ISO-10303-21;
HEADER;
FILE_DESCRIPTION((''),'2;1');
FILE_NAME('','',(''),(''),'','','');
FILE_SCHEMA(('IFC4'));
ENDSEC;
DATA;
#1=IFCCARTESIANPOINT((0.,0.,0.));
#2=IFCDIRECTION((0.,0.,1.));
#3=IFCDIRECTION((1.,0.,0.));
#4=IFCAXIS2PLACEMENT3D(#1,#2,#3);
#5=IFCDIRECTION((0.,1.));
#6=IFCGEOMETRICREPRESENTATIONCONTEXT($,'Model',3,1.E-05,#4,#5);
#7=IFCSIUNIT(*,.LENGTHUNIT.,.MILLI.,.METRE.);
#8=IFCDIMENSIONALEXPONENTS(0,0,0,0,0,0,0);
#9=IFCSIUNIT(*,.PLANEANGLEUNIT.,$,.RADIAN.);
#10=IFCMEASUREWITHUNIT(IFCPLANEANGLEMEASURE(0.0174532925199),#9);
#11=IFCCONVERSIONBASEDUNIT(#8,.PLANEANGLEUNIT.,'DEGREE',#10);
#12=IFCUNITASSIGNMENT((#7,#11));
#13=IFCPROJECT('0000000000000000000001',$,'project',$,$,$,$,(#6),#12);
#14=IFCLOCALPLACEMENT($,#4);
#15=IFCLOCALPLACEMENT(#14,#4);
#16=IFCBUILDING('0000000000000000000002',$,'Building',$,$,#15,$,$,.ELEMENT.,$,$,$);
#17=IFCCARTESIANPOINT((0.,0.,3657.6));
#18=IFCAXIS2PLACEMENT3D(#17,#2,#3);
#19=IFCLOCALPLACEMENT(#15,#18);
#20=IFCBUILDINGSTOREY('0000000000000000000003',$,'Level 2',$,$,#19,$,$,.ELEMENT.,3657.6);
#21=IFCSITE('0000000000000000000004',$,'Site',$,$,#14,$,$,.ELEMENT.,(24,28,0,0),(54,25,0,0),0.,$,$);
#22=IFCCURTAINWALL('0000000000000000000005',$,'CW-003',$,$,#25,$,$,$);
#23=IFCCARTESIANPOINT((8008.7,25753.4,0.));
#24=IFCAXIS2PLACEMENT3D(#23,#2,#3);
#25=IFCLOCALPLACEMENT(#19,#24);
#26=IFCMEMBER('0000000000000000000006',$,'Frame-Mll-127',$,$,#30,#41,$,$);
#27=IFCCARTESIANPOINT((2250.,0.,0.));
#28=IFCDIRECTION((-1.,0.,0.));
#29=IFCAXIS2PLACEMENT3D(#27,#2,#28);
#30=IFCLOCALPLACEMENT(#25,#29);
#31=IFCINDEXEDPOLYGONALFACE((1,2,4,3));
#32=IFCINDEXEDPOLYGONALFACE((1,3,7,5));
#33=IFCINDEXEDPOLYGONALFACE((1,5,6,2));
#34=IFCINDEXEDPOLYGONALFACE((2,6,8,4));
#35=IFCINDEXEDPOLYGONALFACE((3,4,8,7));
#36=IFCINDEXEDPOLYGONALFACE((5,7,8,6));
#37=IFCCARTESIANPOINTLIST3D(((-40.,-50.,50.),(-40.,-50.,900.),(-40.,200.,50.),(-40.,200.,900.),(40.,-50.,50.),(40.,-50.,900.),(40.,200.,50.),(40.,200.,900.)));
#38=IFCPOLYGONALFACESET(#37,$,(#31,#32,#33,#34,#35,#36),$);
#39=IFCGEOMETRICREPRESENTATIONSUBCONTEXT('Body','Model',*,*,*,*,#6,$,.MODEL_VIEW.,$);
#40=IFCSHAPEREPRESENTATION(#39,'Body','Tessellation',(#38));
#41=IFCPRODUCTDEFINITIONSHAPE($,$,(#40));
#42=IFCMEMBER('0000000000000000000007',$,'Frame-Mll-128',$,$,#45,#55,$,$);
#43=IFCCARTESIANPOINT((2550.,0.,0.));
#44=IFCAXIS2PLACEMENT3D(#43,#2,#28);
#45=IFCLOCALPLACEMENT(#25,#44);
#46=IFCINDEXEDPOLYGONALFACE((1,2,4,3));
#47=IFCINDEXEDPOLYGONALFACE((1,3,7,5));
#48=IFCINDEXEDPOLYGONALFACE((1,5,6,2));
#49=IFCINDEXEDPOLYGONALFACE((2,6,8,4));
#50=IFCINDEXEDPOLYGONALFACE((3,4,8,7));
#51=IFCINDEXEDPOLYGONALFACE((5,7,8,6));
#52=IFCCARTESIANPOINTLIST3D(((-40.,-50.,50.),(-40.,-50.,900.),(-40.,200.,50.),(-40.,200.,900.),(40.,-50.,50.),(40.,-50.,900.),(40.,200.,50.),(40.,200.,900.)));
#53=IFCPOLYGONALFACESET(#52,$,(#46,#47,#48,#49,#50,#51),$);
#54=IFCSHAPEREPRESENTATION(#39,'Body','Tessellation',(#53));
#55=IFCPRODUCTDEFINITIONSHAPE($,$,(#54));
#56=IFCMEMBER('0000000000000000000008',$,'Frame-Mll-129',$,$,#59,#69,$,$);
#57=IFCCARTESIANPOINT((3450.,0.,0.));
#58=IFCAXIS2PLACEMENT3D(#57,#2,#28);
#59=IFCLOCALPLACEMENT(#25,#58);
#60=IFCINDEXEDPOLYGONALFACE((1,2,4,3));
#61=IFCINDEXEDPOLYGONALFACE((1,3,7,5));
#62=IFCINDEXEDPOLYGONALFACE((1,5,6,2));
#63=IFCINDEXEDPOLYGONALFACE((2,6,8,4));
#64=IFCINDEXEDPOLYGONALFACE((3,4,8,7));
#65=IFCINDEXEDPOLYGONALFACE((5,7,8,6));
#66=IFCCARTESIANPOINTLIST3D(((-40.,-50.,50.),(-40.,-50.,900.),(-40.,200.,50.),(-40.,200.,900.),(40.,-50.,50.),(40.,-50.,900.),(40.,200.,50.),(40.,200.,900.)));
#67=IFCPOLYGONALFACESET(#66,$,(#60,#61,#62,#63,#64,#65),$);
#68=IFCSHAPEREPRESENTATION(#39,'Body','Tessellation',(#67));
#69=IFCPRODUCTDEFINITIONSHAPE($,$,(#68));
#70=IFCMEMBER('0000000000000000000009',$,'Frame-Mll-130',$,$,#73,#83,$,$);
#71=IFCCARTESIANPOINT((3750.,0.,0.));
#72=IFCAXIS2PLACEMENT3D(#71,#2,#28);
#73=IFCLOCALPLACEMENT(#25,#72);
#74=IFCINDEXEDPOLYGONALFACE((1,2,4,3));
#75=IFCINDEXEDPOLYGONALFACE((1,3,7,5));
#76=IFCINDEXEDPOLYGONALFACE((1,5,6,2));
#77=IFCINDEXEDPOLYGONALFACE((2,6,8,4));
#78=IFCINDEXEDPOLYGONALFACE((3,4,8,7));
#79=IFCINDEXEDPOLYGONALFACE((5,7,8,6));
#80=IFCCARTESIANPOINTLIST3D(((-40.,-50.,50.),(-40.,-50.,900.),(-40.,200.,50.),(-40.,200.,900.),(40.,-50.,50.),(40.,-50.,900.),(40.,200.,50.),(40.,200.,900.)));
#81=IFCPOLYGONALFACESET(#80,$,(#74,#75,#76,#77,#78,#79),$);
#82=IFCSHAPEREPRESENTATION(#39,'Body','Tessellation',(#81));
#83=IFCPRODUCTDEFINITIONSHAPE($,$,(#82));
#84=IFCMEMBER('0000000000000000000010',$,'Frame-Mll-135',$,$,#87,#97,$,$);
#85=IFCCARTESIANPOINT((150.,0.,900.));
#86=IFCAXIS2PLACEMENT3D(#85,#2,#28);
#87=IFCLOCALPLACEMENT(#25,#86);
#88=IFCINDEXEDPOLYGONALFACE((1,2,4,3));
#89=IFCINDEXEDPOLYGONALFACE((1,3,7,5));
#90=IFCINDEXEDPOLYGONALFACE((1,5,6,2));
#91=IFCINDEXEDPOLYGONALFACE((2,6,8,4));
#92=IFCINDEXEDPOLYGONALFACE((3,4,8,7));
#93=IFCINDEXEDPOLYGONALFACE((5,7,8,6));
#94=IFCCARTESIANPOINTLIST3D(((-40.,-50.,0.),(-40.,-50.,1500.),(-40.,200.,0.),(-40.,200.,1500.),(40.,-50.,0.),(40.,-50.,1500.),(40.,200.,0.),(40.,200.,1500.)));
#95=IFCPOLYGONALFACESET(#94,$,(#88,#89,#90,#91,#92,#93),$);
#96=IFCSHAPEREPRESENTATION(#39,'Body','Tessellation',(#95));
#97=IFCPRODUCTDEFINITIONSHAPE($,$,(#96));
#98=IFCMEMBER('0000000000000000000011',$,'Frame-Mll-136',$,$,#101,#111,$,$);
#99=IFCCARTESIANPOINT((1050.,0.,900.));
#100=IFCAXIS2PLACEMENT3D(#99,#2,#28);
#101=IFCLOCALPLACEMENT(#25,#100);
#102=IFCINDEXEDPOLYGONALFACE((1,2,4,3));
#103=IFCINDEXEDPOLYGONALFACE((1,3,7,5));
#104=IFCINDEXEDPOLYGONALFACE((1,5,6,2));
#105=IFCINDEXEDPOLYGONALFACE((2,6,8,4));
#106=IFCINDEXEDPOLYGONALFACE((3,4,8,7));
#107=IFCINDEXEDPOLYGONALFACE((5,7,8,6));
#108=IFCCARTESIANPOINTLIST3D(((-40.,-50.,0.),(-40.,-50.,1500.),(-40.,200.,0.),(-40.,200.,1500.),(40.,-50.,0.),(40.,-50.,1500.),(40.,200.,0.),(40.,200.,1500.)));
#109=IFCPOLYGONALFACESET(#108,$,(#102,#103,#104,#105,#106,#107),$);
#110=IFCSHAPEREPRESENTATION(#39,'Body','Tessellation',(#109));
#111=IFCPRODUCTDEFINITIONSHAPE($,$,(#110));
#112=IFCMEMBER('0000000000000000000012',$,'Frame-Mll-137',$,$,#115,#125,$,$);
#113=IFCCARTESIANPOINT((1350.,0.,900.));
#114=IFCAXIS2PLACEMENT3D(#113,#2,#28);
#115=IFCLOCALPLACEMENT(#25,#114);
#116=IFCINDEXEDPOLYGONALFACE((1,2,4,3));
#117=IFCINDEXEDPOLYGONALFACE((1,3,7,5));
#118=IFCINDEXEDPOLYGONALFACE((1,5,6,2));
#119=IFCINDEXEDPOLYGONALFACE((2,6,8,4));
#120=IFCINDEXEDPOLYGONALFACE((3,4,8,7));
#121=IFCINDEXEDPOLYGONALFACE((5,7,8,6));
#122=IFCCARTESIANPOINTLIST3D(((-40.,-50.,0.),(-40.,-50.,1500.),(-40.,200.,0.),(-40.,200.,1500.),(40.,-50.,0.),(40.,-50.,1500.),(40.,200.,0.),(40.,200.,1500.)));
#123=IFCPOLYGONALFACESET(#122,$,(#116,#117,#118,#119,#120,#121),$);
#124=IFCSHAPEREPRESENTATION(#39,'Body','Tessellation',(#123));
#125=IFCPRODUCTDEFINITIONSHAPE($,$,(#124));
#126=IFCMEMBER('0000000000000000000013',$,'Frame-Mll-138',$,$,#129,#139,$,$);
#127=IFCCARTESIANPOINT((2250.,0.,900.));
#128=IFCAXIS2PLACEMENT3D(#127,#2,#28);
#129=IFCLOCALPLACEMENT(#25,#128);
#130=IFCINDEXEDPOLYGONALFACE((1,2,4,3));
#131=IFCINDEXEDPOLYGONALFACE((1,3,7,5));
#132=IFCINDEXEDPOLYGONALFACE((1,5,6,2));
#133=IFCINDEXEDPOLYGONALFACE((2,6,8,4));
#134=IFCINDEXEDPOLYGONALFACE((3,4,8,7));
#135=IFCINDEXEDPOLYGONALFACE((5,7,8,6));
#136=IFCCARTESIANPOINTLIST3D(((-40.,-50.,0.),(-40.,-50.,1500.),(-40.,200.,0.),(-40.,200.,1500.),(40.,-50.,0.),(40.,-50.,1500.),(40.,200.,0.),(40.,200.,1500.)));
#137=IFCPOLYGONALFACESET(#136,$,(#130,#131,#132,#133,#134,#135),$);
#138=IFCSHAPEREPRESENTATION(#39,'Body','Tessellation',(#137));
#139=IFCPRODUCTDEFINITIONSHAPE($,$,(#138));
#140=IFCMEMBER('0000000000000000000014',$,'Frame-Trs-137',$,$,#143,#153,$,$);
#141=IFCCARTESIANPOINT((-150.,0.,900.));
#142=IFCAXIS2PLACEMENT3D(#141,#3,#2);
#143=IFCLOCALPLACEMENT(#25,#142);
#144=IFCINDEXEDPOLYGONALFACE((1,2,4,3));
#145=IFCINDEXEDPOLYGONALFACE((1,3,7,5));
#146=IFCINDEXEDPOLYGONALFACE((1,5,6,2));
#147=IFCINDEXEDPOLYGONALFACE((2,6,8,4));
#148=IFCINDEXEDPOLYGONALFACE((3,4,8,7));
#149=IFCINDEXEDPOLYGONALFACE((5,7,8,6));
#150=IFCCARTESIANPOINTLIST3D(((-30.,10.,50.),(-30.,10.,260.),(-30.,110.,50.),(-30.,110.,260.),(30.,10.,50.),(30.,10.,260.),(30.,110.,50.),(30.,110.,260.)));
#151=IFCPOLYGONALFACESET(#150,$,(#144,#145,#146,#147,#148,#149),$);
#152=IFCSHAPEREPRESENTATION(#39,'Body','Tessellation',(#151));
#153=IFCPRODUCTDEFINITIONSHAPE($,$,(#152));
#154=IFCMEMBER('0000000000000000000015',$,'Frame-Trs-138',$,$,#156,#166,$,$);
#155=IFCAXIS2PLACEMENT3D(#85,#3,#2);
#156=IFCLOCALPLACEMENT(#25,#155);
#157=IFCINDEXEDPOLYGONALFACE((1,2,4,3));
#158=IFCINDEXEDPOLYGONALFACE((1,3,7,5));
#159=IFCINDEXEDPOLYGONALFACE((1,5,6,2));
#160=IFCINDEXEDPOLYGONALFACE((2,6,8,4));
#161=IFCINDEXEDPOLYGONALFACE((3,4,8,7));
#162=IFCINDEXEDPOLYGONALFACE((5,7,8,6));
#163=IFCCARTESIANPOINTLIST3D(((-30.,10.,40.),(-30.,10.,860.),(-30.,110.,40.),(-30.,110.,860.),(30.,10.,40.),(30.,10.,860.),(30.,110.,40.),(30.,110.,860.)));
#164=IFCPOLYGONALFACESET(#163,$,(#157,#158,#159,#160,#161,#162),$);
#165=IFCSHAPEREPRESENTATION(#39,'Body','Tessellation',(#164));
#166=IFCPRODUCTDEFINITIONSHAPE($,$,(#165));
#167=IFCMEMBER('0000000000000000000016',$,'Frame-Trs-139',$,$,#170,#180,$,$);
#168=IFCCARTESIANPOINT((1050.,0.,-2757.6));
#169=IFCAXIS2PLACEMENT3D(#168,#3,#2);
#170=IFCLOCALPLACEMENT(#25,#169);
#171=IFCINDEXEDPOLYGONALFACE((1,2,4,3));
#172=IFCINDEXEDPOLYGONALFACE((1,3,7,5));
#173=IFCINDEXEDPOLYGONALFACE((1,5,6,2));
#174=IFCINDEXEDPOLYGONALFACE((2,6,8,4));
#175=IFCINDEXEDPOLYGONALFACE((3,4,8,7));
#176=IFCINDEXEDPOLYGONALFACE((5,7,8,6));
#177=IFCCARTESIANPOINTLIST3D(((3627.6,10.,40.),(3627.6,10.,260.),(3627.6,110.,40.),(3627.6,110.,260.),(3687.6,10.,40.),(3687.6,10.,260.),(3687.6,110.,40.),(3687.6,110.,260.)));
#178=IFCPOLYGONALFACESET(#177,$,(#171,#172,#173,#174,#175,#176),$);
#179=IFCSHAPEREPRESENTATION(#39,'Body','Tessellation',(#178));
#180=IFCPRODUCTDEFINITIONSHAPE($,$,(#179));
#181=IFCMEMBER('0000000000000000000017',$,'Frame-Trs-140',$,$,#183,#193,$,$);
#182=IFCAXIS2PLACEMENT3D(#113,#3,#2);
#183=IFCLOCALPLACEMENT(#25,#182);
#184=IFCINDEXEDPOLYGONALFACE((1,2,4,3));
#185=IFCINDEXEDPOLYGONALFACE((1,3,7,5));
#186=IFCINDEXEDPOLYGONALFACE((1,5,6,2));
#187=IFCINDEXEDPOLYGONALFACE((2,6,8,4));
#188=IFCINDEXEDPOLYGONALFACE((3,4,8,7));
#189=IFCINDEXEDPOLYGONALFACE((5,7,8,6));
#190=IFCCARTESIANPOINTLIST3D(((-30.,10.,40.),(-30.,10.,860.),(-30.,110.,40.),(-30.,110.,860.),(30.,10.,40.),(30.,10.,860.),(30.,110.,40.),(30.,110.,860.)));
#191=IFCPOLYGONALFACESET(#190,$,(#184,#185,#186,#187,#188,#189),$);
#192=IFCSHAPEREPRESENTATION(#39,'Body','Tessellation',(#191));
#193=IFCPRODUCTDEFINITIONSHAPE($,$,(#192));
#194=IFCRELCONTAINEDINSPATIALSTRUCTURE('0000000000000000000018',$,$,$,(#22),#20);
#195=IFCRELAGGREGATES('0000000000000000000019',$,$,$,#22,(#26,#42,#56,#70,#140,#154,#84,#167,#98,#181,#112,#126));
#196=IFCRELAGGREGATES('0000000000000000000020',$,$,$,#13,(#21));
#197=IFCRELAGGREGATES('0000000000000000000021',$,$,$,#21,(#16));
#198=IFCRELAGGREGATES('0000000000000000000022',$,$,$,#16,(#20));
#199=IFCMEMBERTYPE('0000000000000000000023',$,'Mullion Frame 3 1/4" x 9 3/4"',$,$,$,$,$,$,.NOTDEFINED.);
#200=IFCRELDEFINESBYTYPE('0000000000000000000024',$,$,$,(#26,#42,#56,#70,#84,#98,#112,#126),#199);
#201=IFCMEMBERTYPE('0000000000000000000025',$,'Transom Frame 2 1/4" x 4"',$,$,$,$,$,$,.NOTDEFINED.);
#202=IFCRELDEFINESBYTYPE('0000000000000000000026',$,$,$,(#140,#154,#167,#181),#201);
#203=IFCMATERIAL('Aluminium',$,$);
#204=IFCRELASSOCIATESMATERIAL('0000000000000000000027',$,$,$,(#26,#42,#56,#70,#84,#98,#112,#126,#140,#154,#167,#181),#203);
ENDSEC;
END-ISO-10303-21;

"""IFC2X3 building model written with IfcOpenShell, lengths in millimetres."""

from ifc_helpers import new_model, entity, si_unit, converted_unit, direction, frame, origin_with_axes, place, context, subcontext, project, spatial, polyline, outline, extrude, material, type_object, element, aggregate, save


model = new_model("IFC2X3")

# Units and contexts
model_context = context("Model", 3, precision=1e-05, world=origin_with_axes(), true_north=direction((0.0, 1.0)))
body_context = subcontext(model_context, "Body", "Model", "MODEL_VIEW")
ifc_project = project(units=[si_unit("LENGTHUNIT", "METRE", prefix="MILLI"), converted_unit("PLANEANGLEUNIT", "DEGREE", entity("IfcPlaneAngleMeasure", 0.0174532925199), si_unit("PLANEANGLEUNIT", "RADIAN"), dimensions=[0, 0, 0, 0, 0, 0, 0])], contexts=[model_context])

# Site, building, storey
site_placement = place(None, origin_with_axes())
site = spatial("IfcSite", under=ifc_project, at=site_placement, Name="Site", CompositionType="ELEMENT", RefLatitude=(24, 28, 0, 0), RefLongitude=(54, 25, 0, 0), RefElevation=0.0)
building_placement = place(site_placement, origin_with_axes())
building = spatial("IfcBuilding", under=site, at=building_placement, Name="Building", CompositionType="ELEMENT")
storey_placement = place(building_placement, frame((0.0, 0.0, 3657.6), z_axis=(0.0, 0.0, 1.0), x_axis=(1.0, 0.0, 0.0)))
storey = spatial("IfcBuildingStorey", under=building, at=storey_placement, Name="Level 2", CompositionType="ELEMENT", Elevation=3657.6)

# Curtain wall, members
curtain_wall_placement = place(storey_placement, frame((8008.7, 25753.4, 0.0), z_axis=(0.0, 0.0, 1.0), x_axis=(1.0, 0.0, 0.0)))
curtain_wall = element("IfcCurtainWall", 1, at=curtain_wall_placement, inside=storey, Name="CW-003")
ifc_material_1 = material(Name="Aluminium")
member_type_1 = type_object("IfcMemberType", Name="Mullion Frame 3 1/4\" x 9 3/4\"", PredefinedType="NOTDEFINED")
member_1_placement = place(curtain_wall_placement, frame((2250.0, 0.0, 0.0), z_axis=(0.0, 0.0, 1.0), x_axis=(-1.0, 0.0, 0.0)))
member_1 = element("IfcMember", 2, at=member_1_placement, type_object=member_type_1, material=ifc_material_1, Name="Frame-Mll-127", context=body_context, shape_type="SweptSolid", body=[
    extrude(outline(polyline([(-40.0, -200.0), (40.0, -200.0), (40.0, 50.0), (-40.0, 50.0), (-40.0, -200.0)])), frame((0.0, 0.0, 50.0), z_axis=(0.0, 0.0, 1.0), x_axis=(-1.0, 0.0, 0.0)), (0.0, 0.0, 1.0), 850.0),
])
member_2_placement = place(curtain_wall_placement, frame((2550.0, 0.0, 0.0), z_axis=(0.0, 0.0, 1.0), x_axis=(-1.0, 0.0, 0.0)))
member_2 = element("IfcMember", 3, at=member_2_placement, type_object=member_type_1, material=ifc_material_1, Name="Frame-Mll-128", context=body_context, shape_type="SweptSolid", body=[
    extrude(outline(polyline([(-40.0, -200.0), (40.0, -200.0), (40.0, 50.0), (-40.0, 50.0), (-40.0, -200.0)])), frame((0.0, 0.0, 50.0), z_axis=(0.0, 0.0, 1.0), x_axis=(-1.0, 0.0, 0.0)), (0.0, 0.0, 1.0), 850.0),
])
member_3_placement = place(curtain_wall_placement, frame((3450.0, 0.0, 0.0), z_axis=(0.0, 0.0, 1.0), x_axis=(-1.0, 0.0, 0.0)))
member_3 = element("IfcMember", 4, at=member_3_placement, type_object=member_type_1, material=ifc_material_1, Name="Frame-Mll-129", context=body_context, shape_type="SweptSolid", body=[
    extrude(outline(polyline([(-40.0, -200.0), (40.0, -200.0), (40.0, 50.0), (-40.0, 50.0), (-40.0, -200.0)])), frame((0.0, 0.0, 50.0), z_axis=(0.0, 0.0, 1.0), x_axis=(-1.0, 0.0, 0.0)), (0.0, 0.0, 1.0), 850.0),
])
member_4_placement = place(curtain_wall_placement, frame((3750.0, 0.0, 0.0), z_axis=(0.0, 0.0, 1.0), x_axis=(-1.0, 0.0, 0.0)))
member_4 = element("IfcMember", 5, at=member_4_placement, type_object=member_type_1, material=ifc_material_1, Name="Frame-Mll-130", context=body_context, shape_type="SweptSolid", body=[
    extrude(outline(polyline([(-40.0, -200.0), (40.0, -200.0), (40.0, 50.0), (-40.0, 50.0), (-40.0, -200.0)])), frame((0.0, 0.0, 50.0), z_axis=(0.0, 0.0, 1.0), x_axis=(-1.0, 0.0, 0.0)), (0.0, 0.0, 1.0), 850.0),
])
member_5_placement = place(curtain_wall_placement, frame((150.0, 0.0, 900.0), z_axis=(0.0, 0.0, 1.0), x_axis=(-1.0, 0.0, 0.0)))
member_5 = element("IfcMember", 6, at=member_5_placement, type_object=member_type_1, material=ifc_material_1, Name="Frame-Mll-135", context=body_context, shape_type="SweptSolid", body=[
    extrude(outline(polyline([(-40.0, -200.0), (40.0, -200.0), (40.0, 50.0), (-40.0, 50.0), (-40.0, -200.0)])), frame((0.0, 0.0, 0.0), z_axis=(0.0, 0.0, 1.0), x_axis=(-1.0, 0.0, 0.0)), (0.0, 0.0, 1.0), 1500.0),
])
member_6_placement = place(curtain_wall_placement, frame((1050.0, 0.0, 900.0), z_axis=(0.0, 0.0, 1.0), x_axis=(-1.0, 0.0, 0.0)))
member_6 = element("IfcMember", 7, at=member_6_placement, type_object=member_type_1, material=ifc_material_1, Name="Frame-Mll-136", context=body_context, shape_type="SweptSolid", body=[
    extrude(outline(polyline([(-40.0, -200.0), (40.0, -200.0), (40.0, 50.0), (-40.0, 50.0), (-40.0, -200.0)])), frame((0.0, 0.0, 0.0), z_axis=(0.0, 0.0, 1.0), x_axis=(-1.0, 0.0, 0.0)), (0.0, 0.0, 1.0), 1500.0),
])
member_7_placement = place(curtain_wall_placement, frame((1350.0, 0.0, 900.0), z_axis=(0.0, 0.0, 1.0), x_axis=(-1.0, 0.0, 0.0)))
member_7 = element("IfcMember", 8, at=member_7_placement, type_object=member_type_1, material=ifc_material_1, Name="Frame-Mll-137", context=body_context, shape_type="SweptSolid", body=[
    extrude(outline(polyline([(-40.0, -200.0), (40.0, -200.0), (40.0, 50.0), (-40.0, 50.0), (-40.0, -200.0)])), frame((0.0, 0.0, 0.0), z_axis=(0.0, 0.0, 1.0), x_axis=(-1.0, 0.0, 0.0)), (0.0, 0.0, 1.0), 1500.0),
])
member_8_placement = place(curtain_wall_placement, frame((2250.0, 0.0, 900.0), z_axis=(0.0, 0.0, 1.0), x_axis=(-1.0, 0.0, 0.0)))
member_8 = element("IfcMember", 9, at=member_8_placement, type_object=member_type_1, material=ifc_material_1, Name="Frame-Mll-138", context=body_context, shape_type="SweptSolid", body=[
    extrude(outline(polyline([(-40.0, -200.0), (40.0, -200.0), (40.0, 50.0), (-40.0, 50.0), (-40.0, -200.0)])), frame((0.0, 0.0, 0.0), z_axis=(0.0, 0.0, 1.0), x_axis=(-1.0, 0.0, 0.0)), (0.0, 0.0, 1.0), 1500.0),
])
member_type_2 = type_object("IfcMemberType", Name="Transom Frame 2 1/4\" x 4\"", PredefinedType="NOTDEFINED")
member_9_placement = place(curtain_wall_placement, frame((-150.0, 0.0, 900.0), z_axis=(1.0, 0.0, 0.0), x_axis=(0.0, 0.0, 1.0)))
member_9 = element("IfcMember", 10, at=member_9_placement, type_object=member_type_2, material=ifc_material_1, Name="Frame-Trs-137", context=body_context, shape_type="SweptSolid", body=[
    extrude(outline(polyline([(110.0, -30.0), (110.0, 30.0), (10.0, 30.0), (10.0, -30.0), (110.0, -30.0)])), frame((0.0, 0.0, 50.0), z_axis=(0.0, 0.0, 1.0), x_axis=(0.0, 1.0, 0.0)), (0.0, 0.0, 1.0), 210.0),
])
member_10_placement = place(curtain_wall_placement, frame((150.0, 0.0, 900.0), z_axis=(1.0, 0.0, 0.0), x_axis=(0.0, 0.0, 1.0)))
member_10 = element("IfcMember", 11, at=member_10_placement, type_object=member_type_2, material=ifc_material_1, Name="Frame-Trs-138", context=body_context, shape_type="SweptSolid", body=[
    extrude(outline(polyline([(110.0, -30.0), (110.0, 30.0), (10.0, 30.0), (10.0, -30.0), (110.0, -30.0)])), frame((0.0, 0.0, 40.0), z_axis=(0.0, 0.0, 1.0), x_axis=(0.0, 1.0, 0.0)), (0.0, 0.0, 1.0), 820.0),
])
member_11_placement = place(curtain_wall_placement, frame((1050.0, 0.0, -2757.6), z_axis=(1.0, 0.0, 0.0), x_axis=(0.0, 0.0, 1.0)))
member_11 = element("IfcMember", 12, at=member_11_placement, type_object=member_type_2, material=ifc_material_1, Name="Frame-Trs-139", context=body_context, shape_type="SweptSolid", body=[
    extrude(outline(polyline([(110.0, -3687.6), (110.0, -3627.6), (10.0, -3627.6), (10.0, -3687.6), (110.0, -3687.6)])), frame((0.0, 0.0, 40.0), z_axis=(0.0, 0.0, 1.0), x_axis=(0.0, 1.0, 0.0)), (0.0, 0.0, 1.0), 220.0),
])
member_12_placement = place(curtain_wall_placement, frame((1350.0, 0.0, 900.0), z_axis=(1.0, 0.0, 0.0), x_axis=(0.0, 0.0, 1.0)))
member_12 = element("IfcMember", 13, at=member_12_placement, type_object=member_type_2, material=ifc_material_1, Name="Frame-Trs-140", context=body_context, shape_type="SweptSolid", body=[
    extrude(outline(polyline([(110.0, -30.0), (110.0, 30.0), (10.0, 30.0), (10.0, -30.0), (110.0, -30.0)])), frame((0.0, 0.0, 40.0), z_axis=(0.0, 0.0, 1.0), x_axis=(0.0, 1.0, 0.0)), (0.0, 0.0, 1.0), 820.0),
])
aggregate(curtain_wall, [member_1, member_2, member_3, member_4, member_9, member_10, member_5, member_11, member_6, member_12, member_7, member_8])

save(model, "model.ifc")
